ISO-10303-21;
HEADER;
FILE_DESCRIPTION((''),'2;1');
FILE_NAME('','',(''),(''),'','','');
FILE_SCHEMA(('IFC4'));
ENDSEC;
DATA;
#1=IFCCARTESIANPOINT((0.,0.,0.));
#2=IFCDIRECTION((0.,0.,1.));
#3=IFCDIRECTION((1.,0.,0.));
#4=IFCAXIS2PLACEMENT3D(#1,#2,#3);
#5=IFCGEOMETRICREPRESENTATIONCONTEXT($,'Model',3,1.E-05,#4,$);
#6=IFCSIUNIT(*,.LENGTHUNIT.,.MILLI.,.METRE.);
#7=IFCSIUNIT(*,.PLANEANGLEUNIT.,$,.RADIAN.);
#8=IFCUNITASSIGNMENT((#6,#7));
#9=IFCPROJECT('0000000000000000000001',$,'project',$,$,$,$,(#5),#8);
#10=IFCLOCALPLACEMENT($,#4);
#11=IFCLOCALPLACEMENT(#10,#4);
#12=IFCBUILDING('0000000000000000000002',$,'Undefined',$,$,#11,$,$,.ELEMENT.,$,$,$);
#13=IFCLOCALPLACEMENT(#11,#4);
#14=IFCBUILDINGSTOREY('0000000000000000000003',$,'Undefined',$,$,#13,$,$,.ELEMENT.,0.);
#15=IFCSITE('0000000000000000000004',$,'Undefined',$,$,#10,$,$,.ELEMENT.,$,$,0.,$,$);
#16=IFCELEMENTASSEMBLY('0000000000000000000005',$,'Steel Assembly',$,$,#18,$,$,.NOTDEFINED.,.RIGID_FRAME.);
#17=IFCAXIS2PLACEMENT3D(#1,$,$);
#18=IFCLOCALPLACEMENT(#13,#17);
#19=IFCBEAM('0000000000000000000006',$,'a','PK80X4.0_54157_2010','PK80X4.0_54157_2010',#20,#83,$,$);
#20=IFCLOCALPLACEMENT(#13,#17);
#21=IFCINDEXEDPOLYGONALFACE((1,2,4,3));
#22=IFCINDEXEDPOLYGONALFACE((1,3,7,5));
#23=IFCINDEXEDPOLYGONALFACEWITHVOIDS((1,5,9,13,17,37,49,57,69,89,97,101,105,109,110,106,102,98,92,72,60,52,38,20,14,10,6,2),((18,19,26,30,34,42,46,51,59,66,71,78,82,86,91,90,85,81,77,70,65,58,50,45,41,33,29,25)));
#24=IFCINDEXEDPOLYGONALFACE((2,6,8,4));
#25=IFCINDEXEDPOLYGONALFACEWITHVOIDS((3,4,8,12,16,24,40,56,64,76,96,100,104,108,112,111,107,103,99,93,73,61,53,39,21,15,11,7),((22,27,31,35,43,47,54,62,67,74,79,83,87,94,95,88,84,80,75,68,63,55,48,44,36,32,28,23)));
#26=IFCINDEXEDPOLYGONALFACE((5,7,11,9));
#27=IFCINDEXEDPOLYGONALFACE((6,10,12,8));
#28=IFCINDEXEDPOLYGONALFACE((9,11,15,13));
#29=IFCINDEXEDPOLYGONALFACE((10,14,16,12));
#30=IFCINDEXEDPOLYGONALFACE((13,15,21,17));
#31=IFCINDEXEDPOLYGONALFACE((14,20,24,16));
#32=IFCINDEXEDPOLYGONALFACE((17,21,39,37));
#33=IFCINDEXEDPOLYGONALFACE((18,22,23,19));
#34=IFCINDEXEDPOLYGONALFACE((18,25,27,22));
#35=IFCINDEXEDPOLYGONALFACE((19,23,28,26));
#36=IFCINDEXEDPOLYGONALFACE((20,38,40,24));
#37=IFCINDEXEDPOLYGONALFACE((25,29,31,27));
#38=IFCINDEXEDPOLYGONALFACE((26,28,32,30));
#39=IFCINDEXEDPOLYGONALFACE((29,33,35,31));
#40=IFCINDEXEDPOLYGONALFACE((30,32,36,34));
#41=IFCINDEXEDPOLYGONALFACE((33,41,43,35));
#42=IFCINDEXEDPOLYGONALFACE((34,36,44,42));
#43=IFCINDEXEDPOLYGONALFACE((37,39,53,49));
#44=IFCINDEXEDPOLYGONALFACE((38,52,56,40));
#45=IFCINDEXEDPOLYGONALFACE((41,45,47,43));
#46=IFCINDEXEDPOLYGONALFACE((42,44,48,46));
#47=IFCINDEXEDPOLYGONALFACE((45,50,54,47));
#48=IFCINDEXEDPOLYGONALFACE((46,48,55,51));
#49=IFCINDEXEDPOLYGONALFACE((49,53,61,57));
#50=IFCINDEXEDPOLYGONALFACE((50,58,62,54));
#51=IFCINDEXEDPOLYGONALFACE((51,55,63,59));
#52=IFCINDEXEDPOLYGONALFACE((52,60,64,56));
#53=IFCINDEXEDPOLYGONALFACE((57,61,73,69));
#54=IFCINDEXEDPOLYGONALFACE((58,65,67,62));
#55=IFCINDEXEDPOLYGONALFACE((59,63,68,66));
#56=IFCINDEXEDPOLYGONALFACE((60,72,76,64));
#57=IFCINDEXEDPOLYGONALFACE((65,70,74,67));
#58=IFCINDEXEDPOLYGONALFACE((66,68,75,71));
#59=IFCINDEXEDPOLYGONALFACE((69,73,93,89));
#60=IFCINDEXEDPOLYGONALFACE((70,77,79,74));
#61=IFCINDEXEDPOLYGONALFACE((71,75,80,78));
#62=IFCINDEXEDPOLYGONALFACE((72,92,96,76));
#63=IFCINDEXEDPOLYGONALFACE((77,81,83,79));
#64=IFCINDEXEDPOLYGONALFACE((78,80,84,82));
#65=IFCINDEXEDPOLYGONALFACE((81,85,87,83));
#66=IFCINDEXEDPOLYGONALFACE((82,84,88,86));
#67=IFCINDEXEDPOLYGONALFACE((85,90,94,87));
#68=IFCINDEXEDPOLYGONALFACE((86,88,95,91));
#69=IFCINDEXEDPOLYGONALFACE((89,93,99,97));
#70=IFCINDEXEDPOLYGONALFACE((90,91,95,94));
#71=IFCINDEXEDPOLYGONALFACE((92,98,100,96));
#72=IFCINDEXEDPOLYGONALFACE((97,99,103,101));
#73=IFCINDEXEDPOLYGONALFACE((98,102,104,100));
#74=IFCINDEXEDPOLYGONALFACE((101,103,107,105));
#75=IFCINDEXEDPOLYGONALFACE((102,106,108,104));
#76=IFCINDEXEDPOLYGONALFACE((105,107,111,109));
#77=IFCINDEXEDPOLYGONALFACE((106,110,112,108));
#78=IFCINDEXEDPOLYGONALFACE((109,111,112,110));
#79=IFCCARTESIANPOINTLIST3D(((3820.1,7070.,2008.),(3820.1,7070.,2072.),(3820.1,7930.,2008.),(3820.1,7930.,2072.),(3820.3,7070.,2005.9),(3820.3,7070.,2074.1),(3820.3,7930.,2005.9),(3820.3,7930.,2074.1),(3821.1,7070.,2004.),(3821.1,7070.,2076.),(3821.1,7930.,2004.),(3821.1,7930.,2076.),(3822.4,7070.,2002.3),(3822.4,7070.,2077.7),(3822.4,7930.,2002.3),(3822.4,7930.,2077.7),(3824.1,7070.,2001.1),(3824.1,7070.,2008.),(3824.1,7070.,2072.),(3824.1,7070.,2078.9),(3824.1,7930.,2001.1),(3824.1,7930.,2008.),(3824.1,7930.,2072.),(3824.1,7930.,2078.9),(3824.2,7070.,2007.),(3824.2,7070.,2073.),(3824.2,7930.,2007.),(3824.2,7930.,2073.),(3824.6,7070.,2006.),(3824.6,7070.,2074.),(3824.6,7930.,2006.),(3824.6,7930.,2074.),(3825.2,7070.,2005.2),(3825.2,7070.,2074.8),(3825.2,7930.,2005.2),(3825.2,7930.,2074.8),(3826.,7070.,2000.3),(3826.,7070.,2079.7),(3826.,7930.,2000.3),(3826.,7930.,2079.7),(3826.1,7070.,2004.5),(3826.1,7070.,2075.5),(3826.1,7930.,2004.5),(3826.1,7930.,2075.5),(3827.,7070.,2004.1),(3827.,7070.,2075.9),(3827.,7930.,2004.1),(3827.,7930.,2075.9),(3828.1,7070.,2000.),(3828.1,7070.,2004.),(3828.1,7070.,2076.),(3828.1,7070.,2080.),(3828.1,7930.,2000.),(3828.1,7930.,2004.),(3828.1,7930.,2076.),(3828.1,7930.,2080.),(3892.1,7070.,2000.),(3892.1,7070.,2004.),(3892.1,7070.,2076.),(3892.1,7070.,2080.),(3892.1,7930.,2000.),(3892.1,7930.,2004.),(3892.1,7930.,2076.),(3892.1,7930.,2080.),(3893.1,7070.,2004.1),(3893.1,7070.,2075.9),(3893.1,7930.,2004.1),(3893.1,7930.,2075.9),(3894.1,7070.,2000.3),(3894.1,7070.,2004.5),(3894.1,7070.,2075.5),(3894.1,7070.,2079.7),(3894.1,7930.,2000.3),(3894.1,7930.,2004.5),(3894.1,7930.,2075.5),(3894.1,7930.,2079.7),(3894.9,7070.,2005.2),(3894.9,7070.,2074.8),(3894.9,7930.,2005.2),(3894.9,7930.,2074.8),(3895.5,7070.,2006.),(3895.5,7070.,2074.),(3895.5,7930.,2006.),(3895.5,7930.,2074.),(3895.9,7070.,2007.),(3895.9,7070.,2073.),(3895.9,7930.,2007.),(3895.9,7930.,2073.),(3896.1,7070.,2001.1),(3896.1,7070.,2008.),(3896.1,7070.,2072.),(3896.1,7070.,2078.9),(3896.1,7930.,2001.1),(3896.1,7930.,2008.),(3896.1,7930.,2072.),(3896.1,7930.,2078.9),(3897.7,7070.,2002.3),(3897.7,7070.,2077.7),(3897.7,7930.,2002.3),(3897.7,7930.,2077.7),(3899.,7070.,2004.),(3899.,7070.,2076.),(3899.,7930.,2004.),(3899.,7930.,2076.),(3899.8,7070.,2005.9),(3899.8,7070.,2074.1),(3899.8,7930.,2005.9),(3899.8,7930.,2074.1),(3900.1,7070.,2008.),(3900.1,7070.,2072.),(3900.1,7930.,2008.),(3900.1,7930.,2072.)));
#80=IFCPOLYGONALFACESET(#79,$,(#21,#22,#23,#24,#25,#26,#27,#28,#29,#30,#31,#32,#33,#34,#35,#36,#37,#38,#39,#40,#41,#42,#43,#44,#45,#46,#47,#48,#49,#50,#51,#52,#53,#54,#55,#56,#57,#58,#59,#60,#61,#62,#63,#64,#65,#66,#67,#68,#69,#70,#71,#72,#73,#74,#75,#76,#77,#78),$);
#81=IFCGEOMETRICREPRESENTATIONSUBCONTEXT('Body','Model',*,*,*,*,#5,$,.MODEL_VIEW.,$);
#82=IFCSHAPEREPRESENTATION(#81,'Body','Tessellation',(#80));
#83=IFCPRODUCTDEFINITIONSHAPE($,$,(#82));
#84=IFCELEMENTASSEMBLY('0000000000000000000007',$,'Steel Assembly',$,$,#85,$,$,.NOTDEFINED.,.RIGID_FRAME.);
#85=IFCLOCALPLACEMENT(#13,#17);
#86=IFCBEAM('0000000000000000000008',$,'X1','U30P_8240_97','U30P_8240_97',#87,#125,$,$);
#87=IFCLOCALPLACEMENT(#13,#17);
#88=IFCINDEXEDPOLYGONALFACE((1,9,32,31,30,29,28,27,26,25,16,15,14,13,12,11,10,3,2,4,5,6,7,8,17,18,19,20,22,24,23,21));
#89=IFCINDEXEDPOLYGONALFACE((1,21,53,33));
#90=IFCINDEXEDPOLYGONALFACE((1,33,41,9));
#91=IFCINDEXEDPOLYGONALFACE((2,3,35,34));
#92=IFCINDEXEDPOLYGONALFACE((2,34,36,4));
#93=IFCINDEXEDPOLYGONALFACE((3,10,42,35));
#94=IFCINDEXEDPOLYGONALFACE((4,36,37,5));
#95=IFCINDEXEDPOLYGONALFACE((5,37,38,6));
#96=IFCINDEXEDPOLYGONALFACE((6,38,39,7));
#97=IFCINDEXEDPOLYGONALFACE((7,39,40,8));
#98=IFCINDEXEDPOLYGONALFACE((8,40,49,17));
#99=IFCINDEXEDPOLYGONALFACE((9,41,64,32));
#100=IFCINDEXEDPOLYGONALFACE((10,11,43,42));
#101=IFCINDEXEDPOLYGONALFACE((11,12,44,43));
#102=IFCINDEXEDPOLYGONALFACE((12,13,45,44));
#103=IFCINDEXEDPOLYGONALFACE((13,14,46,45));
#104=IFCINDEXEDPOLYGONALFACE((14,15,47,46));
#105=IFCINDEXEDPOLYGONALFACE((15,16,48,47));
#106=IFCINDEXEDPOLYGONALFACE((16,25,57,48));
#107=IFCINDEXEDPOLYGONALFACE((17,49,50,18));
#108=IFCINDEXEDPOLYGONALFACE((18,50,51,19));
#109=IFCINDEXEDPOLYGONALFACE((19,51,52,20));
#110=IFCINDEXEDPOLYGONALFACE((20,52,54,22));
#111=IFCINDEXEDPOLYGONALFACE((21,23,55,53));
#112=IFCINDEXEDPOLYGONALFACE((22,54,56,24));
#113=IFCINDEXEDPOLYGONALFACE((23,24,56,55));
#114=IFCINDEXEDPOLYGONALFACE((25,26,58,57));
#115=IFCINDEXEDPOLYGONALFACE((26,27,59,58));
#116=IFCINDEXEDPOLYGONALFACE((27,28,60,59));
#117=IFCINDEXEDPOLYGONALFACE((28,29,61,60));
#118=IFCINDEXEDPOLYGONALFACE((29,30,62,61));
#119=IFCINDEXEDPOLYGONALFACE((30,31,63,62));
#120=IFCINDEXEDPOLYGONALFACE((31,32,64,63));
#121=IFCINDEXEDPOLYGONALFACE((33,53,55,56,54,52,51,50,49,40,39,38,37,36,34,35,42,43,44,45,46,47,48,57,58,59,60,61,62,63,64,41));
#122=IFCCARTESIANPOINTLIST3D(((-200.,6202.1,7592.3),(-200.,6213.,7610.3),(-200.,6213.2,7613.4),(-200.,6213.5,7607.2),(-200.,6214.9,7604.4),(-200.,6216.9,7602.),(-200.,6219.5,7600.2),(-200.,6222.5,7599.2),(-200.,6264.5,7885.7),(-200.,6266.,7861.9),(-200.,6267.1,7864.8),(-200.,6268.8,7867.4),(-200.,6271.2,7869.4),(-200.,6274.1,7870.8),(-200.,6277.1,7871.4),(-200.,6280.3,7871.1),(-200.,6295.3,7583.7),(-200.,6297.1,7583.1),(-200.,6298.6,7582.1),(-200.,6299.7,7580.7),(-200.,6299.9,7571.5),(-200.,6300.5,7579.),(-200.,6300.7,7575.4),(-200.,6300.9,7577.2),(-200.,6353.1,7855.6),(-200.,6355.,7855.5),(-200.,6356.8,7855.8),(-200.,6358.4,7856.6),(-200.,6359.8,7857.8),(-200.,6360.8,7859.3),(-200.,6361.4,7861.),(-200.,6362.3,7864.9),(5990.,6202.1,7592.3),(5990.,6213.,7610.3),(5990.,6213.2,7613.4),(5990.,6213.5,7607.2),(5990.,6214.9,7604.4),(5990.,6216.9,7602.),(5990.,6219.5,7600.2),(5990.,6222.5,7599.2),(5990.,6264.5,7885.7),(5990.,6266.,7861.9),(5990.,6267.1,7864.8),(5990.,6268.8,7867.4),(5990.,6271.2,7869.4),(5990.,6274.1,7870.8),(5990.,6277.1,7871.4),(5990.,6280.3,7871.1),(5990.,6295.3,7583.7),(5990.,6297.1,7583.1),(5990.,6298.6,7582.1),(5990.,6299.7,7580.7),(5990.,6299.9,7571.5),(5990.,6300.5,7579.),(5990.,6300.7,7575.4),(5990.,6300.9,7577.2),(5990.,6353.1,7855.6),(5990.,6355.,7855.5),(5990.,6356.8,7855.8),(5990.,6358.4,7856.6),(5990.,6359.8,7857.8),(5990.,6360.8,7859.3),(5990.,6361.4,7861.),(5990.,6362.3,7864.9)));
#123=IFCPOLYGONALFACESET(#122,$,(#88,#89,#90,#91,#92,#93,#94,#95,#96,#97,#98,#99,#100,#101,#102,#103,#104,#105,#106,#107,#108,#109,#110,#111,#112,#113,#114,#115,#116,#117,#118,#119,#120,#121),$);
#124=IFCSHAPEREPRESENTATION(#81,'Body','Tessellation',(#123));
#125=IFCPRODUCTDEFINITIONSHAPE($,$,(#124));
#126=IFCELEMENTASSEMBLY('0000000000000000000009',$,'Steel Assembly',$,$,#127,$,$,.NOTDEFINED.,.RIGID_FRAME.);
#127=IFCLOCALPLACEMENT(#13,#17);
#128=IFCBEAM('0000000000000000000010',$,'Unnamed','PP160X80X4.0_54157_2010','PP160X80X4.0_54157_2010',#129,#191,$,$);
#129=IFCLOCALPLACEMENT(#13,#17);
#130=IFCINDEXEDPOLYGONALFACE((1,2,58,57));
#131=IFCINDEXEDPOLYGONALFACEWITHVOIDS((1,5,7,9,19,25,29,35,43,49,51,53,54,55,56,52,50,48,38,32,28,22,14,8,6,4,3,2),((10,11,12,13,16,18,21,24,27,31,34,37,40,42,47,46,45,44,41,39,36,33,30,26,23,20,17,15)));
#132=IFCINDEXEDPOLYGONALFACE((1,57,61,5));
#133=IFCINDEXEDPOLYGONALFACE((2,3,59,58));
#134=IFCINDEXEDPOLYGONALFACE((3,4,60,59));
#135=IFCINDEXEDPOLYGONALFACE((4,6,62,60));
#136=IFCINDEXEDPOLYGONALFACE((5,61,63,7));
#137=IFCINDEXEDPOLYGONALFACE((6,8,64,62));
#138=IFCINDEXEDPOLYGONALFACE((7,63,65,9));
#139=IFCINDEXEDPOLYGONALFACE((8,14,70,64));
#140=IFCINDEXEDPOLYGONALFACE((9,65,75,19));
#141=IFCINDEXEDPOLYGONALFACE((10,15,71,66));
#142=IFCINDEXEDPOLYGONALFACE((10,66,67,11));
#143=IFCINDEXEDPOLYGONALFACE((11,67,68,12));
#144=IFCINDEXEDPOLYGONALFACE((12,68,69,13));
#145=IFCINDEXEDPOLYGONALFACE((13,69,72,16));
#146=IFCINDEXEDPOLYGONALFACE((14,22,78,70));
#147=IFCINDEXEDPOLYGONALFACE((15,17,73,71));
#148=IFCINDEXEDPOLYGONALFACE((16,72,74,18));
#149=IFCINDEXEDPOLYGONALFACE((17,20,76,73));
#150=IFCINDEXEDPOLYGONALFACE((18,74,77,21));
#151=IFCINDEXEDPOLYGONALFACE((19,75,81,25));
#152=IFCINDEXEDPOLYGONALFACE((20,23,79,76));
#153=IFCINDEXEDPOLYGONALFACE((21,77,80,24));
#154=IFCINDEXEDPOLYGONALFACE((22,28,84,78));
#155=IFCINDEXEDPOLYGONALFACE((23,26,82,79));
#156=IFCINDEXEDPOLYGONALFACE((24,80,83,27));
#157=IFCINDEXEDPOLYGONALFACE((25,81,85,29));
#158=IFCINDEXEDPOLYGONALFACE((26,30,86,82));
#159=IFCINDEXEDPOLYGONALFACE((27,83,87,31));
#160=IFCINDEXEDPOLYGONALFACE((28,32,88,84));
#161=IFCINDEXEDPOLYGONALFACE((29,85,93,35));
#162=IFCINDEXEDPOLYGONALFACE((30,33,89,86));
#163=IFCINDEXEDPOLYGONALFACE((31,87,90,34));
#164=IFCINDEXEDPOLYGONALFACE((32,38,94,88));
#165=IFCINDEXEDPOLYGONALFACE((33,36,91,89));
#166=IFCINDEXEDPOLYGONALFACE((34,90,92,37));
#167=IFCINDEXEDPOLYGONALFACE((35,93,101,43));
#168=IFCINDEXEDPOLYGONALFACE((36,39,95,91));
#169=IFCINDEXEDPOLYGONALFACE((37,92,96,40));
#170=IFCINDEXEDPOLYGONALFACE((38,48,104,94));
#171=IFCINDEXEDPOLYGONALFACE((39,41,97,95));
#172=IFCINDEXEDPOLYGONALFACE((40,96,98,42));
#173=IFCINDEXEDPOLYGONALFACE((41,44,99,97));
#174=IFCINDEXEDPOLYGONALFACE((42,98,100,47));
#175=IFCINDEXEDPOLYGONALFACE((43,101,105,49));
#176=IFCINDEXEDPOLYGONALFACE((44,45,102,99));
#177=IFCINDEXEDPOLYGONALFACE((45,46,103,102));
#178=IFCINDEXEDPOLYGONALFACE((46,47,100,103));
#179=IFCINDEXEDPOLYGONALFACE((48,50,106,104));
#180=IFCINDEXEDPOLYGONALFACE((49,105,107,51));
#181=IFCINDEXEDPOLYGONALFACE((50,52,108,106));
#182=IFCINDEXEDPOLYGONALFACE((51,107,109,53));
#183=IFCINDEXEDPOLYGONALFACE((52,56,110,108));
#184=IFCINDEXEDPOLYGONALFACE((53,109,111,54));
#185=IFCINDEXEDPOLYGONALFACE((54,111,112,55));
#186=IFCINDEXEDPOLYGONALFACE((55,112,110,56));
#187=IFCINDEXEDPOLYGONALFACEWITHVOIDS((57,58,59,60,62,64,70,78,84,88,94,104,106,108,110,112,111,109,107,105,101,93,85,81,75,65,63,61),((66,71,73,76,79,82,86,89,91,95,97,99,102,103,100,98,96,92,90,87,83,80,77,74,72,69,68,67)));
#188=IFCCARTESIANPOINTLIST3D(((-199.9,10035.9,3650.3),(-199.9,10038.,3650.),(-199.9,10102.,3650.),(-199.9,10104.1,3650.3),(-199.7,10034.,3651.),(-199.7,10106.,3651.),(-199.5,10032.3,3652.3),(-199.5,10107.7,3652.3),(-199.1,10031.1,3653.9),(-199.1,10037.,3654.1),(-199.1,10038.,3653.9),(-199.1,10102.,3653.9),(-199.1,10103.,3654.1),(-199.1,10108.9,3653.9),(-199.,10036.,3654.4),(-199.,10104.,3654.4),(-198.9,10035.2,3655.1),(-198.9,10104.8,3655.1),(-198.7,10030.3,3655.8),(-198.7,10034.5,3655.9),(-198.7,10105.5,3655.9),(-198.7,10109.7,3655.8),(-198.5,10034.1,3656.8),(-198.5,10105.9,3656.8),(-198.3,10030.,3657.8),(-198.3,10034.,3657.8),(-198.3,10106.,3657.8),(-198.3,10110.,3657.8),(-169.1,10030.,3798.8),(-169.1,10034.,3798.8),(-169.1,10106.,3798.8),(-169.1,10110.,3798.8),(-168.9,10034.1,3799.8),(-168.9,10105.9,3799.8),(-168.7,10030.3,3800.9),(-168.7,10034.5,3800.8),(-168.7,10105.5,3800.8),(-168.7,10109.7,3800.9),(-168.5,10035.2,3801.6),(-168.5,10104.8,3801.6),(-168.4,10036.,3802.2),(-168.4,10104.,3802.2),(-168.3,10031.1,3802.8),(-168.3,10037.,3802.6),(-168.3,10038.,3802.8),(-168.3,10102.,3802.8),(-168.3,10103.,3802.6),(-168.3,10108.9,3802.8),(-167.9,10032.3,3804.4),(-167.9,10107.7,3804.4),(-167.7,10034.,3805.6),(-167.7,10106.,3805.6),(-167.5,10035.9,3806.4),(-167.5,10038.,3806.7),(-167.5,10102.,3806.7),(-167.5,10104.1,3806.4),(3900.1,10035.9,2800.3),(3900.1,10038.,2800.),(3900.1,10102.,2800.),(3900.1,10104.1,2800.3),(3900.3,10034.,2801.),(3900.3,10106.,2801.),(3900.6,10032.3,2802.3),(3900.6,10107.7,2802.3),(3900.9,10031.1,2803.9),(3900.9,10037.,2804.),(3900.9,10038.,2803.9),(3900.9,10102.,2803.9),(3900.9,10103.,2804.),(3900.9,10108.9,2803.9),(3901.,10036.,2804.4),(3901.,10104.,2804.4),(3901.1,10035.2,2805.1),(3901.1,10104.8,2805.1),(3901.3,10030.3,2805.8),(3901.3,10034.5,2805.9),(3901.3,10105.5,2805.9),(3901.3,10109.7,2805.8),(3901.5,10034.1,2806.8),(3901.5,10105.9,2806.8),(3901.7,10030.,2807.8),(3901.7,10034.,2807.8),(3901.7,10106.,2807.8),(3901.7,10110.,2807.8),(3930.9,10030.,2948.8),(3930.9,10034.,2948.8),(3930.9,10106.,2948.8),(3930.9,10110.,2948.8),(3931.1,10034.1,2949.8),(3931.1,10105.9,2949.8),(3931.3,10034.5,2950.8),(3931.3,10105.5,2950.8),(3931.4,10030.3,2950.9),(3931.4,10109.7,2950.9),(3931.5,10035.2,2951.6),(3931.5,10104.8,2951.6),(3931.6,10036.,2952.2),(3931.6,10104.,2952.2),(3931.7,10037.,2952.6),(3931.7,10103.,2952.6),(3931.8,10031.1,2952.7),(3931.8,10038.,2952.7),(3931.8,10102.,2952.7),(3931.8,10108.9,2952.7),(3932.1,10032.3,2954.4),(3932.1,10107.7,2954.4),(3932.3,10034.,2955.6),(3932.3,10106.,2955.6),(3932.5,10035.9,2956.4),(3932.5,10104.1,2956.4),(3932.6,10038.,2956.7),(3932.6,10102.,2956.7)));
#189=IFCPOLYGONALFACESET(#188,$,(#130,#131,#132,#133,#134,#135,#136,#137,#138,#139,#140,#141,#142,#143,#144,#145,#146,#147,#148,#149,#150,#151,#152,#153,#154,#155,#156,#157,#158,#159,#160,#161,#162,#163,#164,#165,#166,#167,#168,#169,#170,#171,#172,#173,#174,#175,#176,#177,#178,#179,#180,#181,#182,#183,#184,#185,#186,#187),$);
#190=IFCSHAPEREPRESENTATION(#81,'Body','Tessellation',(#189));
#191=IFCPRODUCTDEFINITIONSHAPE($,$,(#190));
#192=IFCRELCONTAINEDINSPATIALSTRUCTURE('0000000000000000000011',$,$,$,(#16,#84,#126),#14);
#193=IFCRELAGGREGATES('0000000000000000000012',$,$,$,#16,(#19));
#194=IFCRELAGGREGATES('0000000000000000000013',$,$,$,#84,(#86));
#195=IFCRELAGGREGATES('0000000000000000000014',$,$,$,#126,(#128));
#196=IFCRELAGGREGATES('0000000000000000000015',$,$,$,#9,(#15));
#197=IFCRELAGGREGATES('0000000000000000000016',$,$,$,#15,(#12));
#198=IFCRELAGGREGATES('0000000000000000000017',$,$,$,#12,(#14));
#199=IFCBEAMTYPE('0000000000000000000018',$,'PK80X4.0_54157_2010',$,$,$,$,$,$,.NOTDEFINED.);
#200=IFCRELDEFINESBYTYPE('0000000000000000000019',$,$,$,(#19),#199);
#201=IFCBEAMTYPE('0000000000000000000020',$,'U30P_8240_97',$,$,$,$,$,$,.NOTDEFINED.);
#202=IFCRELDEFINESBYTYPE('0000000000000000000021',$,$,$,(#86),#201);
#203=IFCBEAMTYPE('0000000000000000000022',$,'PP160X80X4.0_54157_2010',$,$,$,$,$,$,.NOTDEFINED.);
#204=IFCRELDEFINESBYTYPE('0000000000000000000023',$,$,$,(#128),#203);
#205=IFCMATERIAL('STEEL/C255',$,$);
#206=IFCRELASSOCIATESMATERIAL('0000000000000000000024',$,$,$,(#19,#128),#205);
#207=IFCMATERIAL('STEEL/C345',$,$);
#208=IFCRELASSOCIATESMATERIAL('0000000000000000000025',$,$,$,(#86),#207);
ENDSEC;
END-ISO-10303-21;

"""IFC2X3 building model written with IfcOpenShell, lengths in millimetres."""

from ifc_helpers import new_model, si_unit, frame, origin_with_axes, origin_2d_with_axis, place, context, subcontext, project, spatial, hollow_rectangle, u_section, extrude, material, type_object, element, aggregate, save


model = new_model("IFC2X3")

# Units and contexts
model_context = context("Model", 3, precision=1e-05, world=origin_with_axes())
body_context = subcontext(model_context, "Body", "Model", "MODEL_VIEW")
ifc_project = project(units=[si_unit("LENGTHUNIT", "METRE", prefix="MILLI"), si_unit("PLANEANGLEUNIT", "RADIAN")], contexts=[model_context])

# Site, building, storey
site_placement = place(None, origin_with_axes())
site = spatial("IfcSite", under=ifc_project, at=site_placement, Name="Undefined", CompositionType="ELEMENT", RefElevation=0.0)
building_placement = place(site_placement, origin_with_axes())
building = spatial("IfcBuilding", under=site, at=building_placement, Name="Undefined", CompositionType="ELEMENT")
storey_placement = place(building_placement, origin_with_axes())
storey = spatial("IfcBuildingStorey", under=building, at=storey_placement, Name="Undefined", CompositionType="ELEMENT", Elevation=0.0)

# Element assemblies, beams
ifc_material_1 = material(Name="STEEL/C345")
ifc_material_2 = material(Name="STEEL/C255")
beam_type_1 = type_object("IfcBeamType", Name="PK80X4.0_54157_2010", PredefinedType="NOTDEFINED")
assembly_1_placement = place(storey_placement, origin_with_axes())
assembly_1 = element("IfcElementAssembly", 1, at=assembly_1_placement, inside=storey, Name="Steel Assembly", AssemblyPlace="NOTDEFINED", PredefinedType="RIGID_FRAME")
beam_1_placement = place(assembly_1_placement, frame((3860.1, 7070.0, 2040.0), z_axis=(0.0, 0.0, 1.0), x_axis=(0.0, 1.0, 0.0)))
beam_1 = element("IfcBeam", 2, at=beam_1_placement, type_object=beam_type_1, material=ifc_material_2, Name="a", Description="PK80X4.0_54157_2010", ObjectType="PK80X4.0_54157_2010", context=body_context, shape_type="SweptSolid", body=[
    extrude(hollow_rectangle(XDim=80.0, YDim=80.0, WallThickness=4.0, InnerFilletRadius=4.0, OuterFilletRadius=8.0, at=origin_2d_with_axis()), frame((860.0, 0.0, 0.0), z_axis=(-1.0, 0.0, 0.0), x_axis=(0.0, -1.0, 0.0)), (0.0, 0.0, 1.0), 860.0),
])
aggregate(assembly_1, [beam_1])
assembly_2_placement = place(storey_placement, origin_with_axes())
assembly_2 = element("IfcElementAssembly", 3, at=assembly_2_placement, inside=storey, Name="Steel Assembly", AssemblyPlace="NOTDEFINED", PredefinedType="RIGID_FRAME")
beam_type_2 = type_object("IfcBeamType", Name="U30P_8240_97", PredefinedType="NOTDEFINED")
beam_2_placement = place(assembly_2_placement, frame((-200.0, 6282.2, 7728.6), z_axis=(0.0, -0.207912, -0.978148), x_axis=(1.0, 0.0, 0.0)))
beam_2 = element("IfcBeam", 4, at=beam_2_placement, type_object=beam_type_2, material=ifc_material_1, Name="X1", Description="U30P_8240_97", ObjectType="U30P_8240_97", context=body_context, shape_type="SweptSolid", body=[
    extrude(u_section(Depth=300.0, FlangeWidth=100.0, WebThickness=6.5, FlangeThickness=11.0, FilletRadius=12.0, EdgeRadius=7.0, at=origin_2d_with_axis()), frame((6190.0, 0.0, 0.0), z_axis=(-1.0, 0.0, 0.0), x_axis=(0.0, -1.0, 0.0)), (0.0, 0.0, 1.0), 6190.0),
])
aggregate(assembly_2, [beam_2])
assembly_3_placement = place(storey_placement, origin_with_axes())
assembly_3 = element("IfcElementAssembly", 5, at=assembly_3_placement, inside=storey, Name="Steel Assembly", AssemblyPlace="NOTDEFINED", PredefinedType="RIGID_FRAME")
beam_type_3 = type_object("IfcBeamType", Name="PP160X80X4.0_54157_2010", PredefinedType="NOTDEFINED")
beam_3_placement = place(assembly_3_placement, frame((3916.3, 10070.0, 2878.3), z_axis=(0.203, 0.0, 0.979179), x_axis=(-0.979179, 0.0, 0.203)))
beam_3 = element("IfcBeam", 6, at=beam_3_placement, type_object=beam_type_3, material=ifc_material_2, Name="Unnamed", Description="PP160X80X4.0_54157_2010", ObjectType="PP160X80X4.0_54157_2010", context=body_context, shape_type="SweptSolid", body=[
    extrude(hollow_rectangle(XDim=80.0, YDim=160.0, WallThickness=4.0, InnerFilletRadius=4.0, OuterFilletRadius=8.0, at=origin_2d_with_axis()), frame((4187.2, 0.0, 0.0), z_axis=(-1.0, 0.0, 0.0), x_axis=(0.0, -1.0, 0.0)), (0.0, 0.0, 1.0), 4187.2),
])
aggregate(assembly_3, [beam_3])

save(model, "model.ifc")
